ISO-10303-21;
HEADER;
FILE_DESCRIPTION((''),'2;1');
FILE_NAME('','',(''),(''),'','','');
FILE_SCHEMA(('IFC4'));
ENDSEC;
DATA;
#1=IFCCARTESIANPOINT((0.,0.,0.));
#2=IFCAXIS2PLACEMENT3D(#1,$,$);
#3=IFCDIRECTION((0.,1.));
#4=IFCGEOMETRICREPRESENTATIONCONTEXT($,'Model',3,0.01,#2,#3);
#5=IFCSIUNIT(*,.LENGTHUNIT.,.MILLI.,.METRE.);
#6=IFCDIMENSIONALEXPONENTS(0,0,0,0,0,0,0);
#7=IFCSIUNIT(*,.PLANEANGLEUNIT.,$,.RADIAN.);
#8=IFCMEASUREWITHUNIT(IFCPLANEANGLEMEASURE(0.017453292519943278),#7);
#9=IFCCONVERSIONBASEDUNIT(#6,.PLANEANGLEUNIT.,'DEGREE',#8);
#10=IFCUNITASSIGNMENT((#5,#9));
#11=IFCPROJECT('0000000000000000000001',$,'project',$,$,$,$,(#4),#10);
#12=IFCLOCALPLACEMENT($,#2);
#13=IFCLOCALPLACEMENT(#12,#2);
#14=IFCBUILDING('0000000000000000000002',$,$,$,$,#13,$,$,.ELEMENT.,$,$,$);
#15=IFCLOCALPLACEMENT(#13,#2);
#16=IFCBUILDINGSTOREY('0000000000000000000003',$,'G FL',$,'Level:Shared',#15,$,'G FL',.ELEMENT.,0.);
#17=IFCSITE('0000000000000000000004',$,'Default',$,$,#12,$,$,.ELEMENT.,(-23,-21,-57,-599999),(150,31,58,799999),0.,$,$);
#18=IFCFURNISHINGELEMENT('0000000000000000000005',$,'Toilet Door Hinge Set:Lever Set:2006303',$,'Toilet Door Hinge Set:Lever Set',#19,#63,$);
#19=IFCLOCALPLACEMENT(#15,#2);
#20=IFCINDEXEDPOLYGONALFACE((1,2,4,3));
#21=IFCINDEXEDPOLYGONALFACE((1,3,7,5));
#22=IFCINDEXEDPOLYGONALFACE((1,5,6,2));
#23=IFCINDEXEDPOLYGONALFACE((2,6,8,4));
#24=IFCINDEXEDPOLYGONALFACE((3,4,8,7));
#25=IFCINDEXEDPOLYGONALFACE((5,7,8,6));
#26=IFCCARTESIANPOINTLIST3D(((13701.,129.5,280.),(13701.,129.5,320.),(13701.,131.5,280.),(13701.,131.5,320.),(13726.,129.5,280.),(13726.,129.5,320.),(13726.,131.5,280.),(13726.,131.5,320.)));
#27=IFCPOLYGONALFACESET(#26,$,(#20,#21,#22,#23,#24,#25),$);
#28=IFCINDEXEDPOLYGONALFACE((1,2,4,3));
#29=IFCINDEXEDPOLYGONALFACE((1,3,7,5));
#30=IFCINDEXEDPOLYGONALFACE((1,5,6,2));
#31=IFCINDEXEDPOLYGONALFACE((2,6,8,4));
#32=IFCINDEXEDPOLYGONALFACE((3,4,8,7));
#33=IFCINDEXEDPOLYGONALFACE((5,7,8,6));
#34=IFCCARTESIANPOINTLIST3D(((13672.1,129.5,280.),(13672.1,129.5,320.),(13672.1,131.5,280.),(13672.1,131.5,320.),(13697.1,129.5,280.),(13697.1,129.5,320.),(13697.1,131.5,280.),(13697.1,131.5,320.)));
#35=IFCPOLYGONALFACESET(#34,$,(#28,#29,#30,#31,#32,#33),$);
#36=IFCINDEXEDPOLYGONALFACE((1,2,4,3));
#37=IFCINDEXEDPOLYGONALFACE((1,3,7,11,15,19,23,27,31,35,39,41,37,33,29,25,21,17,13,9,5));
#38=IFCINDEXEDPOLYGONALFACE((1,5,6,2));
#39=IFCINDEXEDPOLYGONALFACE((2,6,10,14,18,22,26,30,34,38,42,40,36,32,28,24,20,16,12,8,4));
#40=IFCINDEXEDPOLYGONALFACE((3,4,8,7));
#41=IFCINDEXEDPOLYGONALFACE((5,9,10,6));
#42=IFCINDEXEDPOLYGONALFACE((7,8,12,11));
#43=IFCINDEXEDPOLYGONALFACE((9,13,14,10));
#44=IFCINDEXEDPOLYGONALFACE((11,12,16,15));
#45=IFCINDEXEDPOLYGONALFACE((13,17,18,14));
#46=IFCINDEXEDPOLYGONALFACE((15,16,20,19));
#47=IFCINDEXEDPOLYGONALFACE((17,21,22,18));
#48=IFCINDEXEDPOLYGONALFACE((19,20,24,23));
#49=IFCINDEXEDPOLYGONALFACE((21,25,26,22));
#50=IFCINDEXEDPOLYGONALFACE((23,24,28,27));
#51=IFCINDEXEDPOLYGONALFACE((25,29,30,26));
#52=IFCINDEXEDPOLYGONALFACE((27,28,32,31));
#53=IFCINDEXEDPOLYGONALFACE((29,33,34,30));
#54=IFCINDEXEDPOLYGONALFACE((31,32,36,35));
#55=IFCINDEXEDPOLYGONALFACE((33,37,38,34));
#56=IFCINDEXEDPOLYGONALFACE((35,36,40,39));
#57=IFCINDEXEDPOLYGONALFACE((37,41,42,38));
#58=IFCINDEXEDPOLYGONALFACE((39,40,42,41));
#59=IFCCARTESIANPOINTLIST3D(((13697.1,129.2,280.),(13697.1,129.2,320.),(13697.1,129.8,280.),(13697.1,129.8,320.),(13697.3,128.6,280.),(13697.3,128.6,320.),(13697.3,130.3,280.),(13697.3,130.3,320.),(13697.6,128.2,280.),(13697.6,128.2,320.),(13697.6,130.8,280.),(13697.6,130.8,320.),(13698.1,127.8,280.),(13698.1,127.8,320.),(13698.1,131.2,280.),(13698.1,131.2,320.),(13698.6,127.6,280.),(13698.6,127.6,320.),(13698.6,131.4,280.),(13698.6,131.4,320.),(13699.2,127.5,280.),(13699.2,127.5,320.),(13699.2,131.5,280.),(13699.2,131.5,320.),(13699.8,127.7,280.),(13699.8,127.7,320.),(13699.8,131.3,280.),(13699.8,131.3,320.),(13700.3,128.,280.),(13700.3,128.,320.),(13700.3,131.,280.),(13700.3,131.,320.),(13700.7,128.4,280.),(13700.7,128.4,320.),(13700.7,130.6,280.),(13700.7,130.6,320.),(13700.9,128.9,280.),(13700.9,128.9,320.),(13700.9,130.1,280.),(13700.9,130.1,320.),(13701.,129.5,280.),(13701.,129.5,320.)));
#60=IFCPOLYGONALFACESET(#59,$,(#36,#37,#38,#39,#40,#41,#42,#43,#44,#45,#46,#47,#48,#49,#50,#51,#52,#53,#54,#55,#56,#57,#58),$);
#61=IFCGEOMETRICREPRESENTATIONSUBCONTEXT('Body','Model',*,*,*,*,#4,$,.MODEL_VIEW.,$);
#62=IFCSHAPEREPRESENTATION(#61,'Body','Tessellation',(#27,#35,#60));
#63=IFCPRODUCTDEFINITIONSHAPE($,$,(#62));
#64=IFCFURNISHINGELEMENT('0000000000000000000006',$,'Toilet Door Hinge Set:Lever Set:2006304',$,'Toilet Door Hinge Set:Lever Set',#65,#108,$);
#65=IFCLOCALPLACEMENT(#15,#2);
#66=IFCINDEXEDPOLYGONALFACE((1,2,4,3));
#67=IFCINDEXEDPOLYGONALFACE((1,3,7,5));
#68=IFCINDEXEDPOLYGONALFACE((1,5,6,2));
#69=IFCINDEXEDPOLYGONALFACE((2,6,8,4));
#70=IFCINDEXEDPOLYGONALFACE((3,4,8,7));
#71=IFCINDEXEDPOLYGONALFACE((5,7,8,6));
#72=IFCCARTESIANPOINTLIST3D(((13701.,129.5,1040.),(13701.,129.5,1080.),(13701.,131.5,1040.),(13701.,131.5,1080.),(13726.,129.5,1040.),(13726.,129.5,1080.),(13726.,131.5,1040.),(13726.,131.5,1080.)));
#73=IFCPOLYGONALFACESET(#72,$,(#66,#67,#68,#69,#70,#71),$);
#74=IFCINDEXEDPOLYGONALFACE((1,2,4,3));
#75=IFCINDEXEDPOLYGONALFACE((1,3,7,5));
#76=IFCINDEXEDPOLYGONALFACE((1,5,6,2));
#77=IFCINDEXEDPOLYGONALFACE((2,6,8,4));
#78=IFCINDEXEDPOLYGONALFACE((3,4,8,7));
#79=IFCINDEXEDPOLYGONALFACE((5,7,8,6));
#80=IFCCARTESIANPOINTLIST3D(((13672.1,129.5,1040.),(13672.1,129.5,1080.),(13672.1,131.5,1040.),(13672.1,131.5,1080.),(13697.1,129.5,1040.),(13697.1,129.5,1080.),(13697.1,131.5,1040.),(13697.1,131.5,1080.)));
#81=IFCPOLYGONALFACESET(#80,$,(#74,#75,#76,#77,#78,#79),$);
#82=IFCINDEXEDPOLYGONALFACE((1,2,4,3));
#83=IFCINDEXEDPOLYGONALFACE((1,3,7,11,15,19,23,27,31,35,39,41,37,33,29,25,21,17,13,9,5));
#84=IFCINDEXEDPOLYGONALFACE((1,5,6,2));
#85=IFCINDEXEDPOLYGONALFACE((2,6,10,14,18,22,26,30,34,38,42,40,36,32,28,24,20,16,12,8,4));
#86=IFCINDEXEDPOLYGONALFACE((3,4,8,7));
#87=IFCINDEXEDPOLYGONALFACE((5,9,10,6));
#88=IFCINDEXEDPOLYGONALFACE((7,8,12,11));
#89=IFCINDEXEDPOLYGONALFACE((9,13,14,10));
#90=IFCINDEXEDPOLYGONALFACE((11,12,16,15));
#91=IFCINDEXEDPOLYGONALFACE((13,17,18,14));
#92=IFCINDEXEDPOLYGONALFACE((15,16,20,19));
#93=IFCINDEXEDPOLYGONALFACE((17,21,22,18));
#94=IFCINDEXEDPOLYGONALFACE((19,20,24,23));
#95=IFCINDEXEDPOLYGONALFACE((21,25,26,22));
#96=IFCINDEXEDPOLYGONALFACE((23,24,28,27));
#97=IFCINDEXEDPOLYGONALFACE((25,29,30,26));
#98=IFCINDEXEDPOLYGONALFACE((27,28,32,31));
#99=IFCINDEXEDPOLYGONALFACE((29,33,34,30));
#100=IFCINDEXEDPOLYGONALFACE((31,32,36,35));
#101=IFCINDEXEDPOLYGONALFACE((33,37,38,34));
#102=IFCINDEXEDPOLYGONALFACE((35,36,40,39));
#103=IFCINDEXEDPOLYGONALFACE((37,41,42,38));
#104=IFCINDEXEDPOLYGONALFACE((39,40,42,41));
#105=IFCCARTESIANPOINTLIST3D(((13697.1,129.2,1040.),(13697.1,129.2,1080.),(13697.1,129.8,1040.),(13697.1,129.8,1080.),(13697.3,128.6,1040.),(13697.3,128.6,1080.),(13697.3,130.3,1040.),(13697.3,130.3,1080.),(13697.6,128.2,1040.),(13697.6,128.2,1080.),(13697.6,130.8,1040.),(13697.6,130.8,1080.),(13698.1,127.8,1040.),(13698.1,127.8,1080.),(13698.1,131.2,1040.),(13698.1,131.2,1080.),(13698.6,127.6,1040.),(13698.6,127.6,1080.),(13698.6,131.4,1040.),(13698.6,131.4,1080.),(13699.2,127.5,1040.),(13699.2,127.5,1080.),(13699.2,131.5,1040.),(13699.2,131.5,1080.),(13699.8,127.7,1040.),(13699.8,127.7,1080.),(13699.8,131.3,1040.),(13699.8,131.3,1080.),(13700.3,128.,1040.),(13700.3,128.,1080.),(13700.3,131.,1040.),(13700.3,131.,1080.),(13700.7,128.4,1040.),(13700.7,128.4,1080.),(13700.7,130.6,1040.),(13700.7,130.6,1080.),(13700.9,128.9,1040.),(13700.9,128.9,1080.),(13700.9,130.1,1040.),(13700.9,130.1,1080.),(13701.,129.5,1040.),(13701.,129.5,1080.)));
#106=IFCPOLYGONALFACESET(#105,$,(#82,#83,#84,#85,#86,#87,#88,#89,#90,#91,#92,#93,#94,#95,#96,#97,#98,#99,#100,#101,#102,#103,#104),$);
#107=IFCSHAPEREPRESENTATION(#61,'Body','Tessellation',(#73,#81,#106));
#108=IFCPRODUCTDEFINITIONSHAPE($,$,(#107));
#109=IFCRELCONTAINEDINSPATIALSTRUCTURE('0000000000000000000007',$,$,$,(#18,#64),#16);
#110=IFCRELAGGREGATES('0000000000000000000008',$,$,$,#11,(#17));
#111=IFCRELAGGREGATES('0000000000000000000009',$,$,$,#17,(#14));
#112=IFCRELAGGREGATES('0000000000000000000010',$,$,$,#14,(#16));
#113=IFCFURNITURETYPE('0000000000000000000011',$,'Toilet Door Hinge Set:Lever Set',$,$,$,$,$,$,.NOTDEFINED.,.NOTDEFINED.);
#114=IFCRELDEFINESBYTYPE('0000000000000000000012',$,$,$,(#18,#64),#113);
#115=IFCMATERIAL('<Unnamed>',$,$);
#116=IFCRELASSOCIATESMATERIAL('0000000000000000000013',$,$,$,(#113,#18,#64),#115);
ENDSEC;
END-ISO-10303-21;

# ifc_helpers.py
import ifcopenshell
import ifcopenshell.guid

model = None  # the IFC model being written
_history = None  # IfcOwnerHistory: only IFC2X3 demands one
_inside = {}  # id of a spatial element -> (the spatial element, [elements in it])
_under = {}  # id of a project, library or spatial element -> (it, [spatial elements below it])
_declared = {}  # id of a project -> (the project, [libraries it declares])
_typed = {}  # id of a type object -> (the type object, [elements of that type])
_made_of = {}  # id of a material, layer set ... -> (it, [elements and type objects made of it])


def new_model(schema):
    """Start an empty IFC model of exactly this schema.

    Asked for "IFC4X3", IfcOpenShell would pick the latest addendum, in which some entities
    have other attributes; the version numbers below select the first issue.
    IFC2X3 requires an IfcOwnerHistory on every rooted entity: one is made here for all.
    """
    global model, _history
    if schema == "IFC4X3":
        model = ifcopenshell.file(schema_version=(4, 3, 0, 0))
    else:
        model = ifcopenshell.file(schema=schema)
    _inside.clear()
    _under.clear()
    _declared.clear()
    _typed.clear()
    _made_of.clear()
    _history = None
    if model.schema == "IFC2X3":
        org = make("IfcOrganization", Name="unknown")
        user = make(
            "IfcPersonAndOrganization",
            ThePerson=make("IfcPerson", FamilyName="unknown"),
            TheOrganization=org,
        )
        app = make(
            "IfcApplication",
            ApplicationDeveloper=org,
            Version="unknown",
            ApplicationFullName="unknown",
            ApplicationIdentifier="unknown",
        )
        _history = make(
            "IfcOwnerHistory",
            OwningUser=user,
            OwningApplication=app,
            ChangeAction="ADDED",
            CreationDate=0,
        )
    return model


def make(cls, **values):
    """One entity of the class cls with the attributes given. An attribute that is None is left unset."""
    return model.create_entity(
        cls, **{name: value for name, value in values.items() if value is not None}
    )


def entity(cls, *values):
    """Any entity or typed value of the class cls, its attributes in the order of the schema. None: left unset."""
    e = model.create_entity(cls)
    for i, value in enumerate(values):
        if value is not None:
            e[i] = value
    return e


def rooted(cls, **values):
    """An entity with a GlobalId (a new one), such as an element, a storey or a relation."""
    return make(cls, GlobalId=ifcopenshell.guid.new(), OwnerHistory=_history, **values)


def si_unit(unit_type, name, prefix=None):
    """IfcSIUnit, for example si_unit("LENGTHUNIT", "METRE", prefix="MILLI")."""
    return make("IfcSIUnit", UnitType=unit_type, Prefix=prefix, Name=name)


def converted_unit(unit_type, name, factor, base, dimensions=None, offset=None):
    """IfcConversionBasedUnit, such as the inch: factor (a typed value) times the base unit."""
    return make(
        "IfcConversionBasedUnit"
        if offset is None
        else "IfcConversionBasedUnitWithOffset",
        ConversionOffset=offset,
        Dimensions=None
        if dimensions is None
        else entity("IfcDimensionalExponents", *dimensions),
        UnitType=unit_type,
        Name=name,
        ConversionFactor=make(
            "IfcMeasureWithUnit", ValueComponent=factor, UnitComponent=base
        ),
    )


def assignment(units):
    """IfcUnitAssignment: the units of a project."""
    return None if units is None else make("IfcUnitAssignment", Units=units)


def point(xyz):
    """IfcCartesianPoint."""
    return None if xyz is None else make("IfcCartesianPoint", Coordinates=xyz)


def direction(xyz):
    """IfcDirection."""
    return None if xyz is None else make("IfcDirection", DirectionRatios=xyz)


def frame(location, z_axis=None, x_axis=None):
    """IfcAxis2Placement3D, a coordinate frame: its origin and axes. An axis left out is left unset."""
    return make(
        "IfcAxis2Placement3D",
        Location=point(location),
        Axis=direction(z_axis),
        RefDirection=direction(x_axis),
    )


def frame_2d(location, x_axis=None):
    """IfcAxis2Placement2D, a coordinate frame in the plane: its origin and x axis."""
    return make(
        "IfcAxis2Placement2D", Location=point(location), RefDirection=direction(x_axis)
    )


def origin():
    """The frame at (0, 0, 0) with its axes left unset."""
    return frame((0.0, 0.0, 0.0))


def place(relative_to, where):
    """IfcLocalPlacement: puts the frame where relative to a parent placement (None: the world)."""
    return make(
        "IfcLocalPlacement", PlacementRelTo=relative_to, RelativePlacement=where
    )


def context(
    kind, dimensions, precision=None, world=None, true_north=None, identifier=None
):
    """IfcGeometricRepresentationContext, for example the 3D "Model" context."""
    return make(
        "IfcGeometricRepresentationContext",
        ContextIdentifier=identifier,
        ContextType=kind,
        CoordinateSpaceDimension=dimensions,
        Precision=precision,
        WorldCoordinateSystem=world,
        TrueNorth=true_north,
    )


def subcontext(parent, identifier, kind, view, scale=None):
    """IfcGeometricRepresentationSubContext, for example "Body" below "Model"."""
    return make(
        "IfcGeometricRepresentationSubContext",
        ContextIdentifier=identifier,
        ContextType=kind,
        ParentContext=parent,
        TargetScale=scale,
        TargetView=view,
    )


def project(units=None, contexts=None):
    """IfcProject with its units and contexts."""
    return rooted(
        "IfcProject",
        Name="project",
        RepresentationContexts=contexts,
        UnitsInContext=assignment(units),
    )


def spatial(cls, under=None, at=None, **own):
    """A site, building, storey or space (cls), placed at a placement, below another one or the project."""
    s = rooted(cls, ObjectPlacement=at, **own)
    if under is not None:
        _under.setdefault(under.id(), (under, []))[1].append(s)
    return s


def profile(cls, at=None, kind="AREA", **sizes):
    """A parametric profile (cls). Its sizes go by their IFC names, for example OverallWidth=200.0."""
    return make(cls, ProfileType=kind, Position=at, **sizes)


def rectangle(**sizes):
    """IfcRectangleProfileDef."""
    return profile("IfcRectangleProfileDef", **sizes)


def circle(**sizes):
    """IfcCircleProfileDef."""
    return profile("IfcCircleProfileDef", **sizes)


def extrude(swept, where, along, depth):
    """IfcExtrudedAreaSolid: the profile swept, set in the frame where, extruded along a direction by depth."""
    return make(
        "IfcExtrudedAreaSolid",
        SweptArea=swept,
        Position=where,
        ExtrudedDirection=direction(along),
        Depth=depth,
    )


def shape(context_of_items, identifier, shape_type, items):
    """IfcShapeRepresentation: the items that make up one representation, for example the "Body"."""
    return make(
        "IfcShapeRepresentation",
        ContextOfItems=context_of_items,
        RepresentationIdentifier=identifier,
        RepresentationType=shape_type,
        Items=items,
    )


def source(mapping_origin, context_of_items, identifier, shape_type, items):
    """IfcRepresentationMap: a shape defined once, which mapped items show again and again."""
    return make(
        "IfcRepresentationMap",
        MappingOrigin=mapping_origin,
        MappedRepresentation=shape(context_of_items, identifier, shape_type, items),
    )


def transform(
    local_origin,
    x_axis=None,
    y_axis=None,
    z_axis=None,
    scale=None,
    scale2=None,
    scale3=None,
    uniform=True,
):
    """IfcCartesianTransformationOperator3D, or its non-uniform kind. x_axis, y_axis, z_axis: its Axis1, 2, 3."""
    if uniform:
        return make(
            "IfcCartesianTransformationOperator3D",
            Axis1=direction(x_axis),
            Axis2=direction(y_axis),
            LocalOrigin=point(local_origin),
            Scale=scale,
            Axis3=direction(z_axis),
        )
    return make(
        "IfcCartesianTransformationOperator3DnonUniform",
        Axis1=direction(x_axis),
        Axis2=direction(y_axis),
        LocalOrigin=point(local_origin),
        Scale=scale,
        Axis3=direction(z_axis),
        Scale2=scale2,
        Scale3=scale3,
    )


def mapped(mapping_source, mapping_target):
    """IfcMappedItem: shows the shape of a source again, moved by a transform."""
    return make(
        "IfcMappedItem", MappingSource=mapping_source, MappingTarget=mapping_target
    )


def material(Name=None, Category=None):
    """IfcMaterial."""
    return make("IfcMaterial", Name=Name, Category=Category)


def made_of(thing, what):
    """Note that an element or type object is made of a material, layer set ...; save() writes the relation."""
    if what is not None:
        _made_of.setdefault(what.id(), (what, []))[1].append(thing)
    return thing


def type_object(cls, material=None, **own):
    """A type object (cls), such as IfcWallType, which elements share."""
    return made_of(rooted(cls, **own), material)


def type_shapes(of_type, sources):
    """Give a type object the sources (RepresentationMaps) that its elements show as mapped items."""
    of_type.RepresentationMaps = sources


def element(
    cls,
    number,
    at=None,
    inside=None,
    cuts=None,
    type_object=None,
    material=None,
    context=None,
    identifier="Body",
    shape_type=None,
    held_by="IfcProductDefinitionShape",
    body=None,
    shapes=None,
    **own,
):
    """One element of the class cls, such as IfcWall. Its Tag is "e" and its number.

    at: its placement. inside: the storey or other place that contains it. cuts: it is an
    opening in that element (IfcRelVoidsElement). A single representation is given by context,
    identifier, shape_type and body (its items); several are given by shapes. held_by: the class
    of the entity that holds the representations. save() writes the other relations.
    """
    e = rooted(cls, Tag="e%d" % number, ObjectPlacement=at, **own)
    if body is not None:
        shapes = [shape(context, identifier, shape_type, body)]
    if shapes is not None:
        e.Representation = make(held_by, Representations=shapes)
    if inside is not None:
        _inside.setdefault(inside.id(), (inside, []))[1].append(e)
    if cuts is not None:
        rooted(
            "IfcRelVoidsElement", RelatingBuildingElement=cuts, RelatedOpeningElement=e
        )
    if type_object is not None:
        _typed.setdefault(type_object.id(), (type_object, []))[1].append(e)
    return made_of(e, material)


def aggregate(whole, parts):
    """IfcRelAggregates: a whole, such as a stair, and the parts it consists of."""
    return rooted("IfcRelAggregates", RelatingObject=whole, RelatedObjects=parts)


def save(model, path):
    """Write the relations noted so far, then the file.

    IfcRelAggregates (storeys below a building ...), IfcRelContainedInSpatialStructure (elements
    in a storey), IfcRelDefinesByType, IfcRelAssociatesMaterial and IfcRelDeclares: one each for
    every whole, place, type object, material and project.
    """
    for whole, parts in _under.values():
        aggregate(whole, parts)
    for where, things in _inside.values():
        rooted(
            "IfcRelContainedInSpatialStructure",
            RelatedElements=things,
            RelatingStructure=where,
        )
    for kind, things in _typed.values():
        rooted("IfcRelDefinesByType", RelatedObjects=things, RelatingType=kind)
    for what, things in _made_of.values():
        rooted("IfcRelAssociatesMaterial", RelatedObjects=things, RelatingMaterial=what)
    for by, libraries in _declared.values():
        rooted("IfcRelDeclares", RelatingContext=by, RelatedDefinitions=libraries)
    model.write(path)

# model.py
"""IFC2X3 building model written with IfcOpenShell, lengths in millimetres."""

from ifc_helpers import new_model, entity, si_unit, converted_unit, direction, frame, frame_2d, origin, place, context, subcontext, project, spatial, rectangle, circle, extrude, source, transform, mapped, material, type_object, type_shapes, element, save


model = new_model("IFC2X3")

# Units and contexts
model_context = context("Model", 3, precision=0.01, world=origin(), true_north=direction((0.0, 1.0)))
body_context = subcontext(model_context, "Body", "Model", "MODEL_VIEW")
ifc_project = project(units=[si_unit("LENGTHUNIT", "METRE", prefix="MILLI"), converted_unit("PLANEANGLEUNIT", "DEGREE", entity("IfcPlaneAngleMeasure", 0.017453292519943278), si_unit("PLANEANGLEUNIT", "RADIAN"), dimensions=[0, 0, 0, 0, 0, 0, 0])], contexts=[model_context])

# Site, building, storey
site_placement = place(None, origin())
site = spatial("IfcSite", under=ifc_project, at=site_placement, Name="Default", CompositionType="ELEMENT", RefLatitude=(-23, -21, -57, -599999), RefLongitude=(150, 31, 58, 799999), RefElevation=0.0)
building_placement = place(site_placement, origin())
building = spatial("IfcBuilding", under=site, at=building_placement, CompositionType="ELEMENT")
storey_placement = place(building_placement, origin())
storey = spatial("IfcBuildingStorey", under=building, at=storey_placement, Name="G FL", ObjectType="Level:Shared", LongName="G FL", CompositionType="ELEMENT", Elevation=0.0)

# Furnishing elements
ifc_material_1 = material(Name="<Unnamed>")
furniture_type = type_object("IfcFurnitureType", Name="Toilet Door Hinge Set:Lever Set", AssemblyPlace="NOTDEFINED", material=ifc_material_1)
shared_shape_1 = source(origin(), body_context, "Body", "SweptSolid", [
    extrude(rectangle(XDim=2.0, YDim=25.0, at=frame_2d((0.0, 0.0), x_axis=(1.0, 0.0))), frame((14.5, 1.0, -20.0), z_axis=(0.0, 0.0, 1.0), x_axis=(0.0, 1.0, 0.0)), (0.0, 0.0, 1.0), 40.0),
    extrude(rectangle(XDim=25.0, YDim=2.0, at=frame_2d((0.0, 0.0), x_axis=(1.0, 0.0))), frame((-14.5, 1.0, -20.0)), (0.0, 0.0, 1.0), 40.0),
    extrude(circle(Radius=2.0, at=frame_2d((0.0, 0.0), x_axis=(1.0, 0.0))), frame((0.0, 0.0, -20.0)), (0.0, 0.0, 1.0), 40.0),
])
type_shapes(furniture_type, [shared_shape_1])
for number, where, name in (
    (1, (13699.0, 129.5, 300.0), "Toilet Door Hinge Set:Lever Set:2006303"),
    (2, (13699.0, 129.5, 1060.0), "Toilet Door Hinge Set:Lever Set:2006304"),
):
    element("IfcFurnishingElement", number, at=place(storey_placement, frame(where)), inside=storey, type_object=furniture_type, material=ifc_material_1, Name=name, ObjectType="Toilet Door Hinge Set:Lever Set", context=body_context, shape_type="MappedRepresentation", body=[
        mapped(shared_shape_1, transform((0.0, 0.0, 0.0), scale=1.0)),
    ])

save(model, "model.ifc")
